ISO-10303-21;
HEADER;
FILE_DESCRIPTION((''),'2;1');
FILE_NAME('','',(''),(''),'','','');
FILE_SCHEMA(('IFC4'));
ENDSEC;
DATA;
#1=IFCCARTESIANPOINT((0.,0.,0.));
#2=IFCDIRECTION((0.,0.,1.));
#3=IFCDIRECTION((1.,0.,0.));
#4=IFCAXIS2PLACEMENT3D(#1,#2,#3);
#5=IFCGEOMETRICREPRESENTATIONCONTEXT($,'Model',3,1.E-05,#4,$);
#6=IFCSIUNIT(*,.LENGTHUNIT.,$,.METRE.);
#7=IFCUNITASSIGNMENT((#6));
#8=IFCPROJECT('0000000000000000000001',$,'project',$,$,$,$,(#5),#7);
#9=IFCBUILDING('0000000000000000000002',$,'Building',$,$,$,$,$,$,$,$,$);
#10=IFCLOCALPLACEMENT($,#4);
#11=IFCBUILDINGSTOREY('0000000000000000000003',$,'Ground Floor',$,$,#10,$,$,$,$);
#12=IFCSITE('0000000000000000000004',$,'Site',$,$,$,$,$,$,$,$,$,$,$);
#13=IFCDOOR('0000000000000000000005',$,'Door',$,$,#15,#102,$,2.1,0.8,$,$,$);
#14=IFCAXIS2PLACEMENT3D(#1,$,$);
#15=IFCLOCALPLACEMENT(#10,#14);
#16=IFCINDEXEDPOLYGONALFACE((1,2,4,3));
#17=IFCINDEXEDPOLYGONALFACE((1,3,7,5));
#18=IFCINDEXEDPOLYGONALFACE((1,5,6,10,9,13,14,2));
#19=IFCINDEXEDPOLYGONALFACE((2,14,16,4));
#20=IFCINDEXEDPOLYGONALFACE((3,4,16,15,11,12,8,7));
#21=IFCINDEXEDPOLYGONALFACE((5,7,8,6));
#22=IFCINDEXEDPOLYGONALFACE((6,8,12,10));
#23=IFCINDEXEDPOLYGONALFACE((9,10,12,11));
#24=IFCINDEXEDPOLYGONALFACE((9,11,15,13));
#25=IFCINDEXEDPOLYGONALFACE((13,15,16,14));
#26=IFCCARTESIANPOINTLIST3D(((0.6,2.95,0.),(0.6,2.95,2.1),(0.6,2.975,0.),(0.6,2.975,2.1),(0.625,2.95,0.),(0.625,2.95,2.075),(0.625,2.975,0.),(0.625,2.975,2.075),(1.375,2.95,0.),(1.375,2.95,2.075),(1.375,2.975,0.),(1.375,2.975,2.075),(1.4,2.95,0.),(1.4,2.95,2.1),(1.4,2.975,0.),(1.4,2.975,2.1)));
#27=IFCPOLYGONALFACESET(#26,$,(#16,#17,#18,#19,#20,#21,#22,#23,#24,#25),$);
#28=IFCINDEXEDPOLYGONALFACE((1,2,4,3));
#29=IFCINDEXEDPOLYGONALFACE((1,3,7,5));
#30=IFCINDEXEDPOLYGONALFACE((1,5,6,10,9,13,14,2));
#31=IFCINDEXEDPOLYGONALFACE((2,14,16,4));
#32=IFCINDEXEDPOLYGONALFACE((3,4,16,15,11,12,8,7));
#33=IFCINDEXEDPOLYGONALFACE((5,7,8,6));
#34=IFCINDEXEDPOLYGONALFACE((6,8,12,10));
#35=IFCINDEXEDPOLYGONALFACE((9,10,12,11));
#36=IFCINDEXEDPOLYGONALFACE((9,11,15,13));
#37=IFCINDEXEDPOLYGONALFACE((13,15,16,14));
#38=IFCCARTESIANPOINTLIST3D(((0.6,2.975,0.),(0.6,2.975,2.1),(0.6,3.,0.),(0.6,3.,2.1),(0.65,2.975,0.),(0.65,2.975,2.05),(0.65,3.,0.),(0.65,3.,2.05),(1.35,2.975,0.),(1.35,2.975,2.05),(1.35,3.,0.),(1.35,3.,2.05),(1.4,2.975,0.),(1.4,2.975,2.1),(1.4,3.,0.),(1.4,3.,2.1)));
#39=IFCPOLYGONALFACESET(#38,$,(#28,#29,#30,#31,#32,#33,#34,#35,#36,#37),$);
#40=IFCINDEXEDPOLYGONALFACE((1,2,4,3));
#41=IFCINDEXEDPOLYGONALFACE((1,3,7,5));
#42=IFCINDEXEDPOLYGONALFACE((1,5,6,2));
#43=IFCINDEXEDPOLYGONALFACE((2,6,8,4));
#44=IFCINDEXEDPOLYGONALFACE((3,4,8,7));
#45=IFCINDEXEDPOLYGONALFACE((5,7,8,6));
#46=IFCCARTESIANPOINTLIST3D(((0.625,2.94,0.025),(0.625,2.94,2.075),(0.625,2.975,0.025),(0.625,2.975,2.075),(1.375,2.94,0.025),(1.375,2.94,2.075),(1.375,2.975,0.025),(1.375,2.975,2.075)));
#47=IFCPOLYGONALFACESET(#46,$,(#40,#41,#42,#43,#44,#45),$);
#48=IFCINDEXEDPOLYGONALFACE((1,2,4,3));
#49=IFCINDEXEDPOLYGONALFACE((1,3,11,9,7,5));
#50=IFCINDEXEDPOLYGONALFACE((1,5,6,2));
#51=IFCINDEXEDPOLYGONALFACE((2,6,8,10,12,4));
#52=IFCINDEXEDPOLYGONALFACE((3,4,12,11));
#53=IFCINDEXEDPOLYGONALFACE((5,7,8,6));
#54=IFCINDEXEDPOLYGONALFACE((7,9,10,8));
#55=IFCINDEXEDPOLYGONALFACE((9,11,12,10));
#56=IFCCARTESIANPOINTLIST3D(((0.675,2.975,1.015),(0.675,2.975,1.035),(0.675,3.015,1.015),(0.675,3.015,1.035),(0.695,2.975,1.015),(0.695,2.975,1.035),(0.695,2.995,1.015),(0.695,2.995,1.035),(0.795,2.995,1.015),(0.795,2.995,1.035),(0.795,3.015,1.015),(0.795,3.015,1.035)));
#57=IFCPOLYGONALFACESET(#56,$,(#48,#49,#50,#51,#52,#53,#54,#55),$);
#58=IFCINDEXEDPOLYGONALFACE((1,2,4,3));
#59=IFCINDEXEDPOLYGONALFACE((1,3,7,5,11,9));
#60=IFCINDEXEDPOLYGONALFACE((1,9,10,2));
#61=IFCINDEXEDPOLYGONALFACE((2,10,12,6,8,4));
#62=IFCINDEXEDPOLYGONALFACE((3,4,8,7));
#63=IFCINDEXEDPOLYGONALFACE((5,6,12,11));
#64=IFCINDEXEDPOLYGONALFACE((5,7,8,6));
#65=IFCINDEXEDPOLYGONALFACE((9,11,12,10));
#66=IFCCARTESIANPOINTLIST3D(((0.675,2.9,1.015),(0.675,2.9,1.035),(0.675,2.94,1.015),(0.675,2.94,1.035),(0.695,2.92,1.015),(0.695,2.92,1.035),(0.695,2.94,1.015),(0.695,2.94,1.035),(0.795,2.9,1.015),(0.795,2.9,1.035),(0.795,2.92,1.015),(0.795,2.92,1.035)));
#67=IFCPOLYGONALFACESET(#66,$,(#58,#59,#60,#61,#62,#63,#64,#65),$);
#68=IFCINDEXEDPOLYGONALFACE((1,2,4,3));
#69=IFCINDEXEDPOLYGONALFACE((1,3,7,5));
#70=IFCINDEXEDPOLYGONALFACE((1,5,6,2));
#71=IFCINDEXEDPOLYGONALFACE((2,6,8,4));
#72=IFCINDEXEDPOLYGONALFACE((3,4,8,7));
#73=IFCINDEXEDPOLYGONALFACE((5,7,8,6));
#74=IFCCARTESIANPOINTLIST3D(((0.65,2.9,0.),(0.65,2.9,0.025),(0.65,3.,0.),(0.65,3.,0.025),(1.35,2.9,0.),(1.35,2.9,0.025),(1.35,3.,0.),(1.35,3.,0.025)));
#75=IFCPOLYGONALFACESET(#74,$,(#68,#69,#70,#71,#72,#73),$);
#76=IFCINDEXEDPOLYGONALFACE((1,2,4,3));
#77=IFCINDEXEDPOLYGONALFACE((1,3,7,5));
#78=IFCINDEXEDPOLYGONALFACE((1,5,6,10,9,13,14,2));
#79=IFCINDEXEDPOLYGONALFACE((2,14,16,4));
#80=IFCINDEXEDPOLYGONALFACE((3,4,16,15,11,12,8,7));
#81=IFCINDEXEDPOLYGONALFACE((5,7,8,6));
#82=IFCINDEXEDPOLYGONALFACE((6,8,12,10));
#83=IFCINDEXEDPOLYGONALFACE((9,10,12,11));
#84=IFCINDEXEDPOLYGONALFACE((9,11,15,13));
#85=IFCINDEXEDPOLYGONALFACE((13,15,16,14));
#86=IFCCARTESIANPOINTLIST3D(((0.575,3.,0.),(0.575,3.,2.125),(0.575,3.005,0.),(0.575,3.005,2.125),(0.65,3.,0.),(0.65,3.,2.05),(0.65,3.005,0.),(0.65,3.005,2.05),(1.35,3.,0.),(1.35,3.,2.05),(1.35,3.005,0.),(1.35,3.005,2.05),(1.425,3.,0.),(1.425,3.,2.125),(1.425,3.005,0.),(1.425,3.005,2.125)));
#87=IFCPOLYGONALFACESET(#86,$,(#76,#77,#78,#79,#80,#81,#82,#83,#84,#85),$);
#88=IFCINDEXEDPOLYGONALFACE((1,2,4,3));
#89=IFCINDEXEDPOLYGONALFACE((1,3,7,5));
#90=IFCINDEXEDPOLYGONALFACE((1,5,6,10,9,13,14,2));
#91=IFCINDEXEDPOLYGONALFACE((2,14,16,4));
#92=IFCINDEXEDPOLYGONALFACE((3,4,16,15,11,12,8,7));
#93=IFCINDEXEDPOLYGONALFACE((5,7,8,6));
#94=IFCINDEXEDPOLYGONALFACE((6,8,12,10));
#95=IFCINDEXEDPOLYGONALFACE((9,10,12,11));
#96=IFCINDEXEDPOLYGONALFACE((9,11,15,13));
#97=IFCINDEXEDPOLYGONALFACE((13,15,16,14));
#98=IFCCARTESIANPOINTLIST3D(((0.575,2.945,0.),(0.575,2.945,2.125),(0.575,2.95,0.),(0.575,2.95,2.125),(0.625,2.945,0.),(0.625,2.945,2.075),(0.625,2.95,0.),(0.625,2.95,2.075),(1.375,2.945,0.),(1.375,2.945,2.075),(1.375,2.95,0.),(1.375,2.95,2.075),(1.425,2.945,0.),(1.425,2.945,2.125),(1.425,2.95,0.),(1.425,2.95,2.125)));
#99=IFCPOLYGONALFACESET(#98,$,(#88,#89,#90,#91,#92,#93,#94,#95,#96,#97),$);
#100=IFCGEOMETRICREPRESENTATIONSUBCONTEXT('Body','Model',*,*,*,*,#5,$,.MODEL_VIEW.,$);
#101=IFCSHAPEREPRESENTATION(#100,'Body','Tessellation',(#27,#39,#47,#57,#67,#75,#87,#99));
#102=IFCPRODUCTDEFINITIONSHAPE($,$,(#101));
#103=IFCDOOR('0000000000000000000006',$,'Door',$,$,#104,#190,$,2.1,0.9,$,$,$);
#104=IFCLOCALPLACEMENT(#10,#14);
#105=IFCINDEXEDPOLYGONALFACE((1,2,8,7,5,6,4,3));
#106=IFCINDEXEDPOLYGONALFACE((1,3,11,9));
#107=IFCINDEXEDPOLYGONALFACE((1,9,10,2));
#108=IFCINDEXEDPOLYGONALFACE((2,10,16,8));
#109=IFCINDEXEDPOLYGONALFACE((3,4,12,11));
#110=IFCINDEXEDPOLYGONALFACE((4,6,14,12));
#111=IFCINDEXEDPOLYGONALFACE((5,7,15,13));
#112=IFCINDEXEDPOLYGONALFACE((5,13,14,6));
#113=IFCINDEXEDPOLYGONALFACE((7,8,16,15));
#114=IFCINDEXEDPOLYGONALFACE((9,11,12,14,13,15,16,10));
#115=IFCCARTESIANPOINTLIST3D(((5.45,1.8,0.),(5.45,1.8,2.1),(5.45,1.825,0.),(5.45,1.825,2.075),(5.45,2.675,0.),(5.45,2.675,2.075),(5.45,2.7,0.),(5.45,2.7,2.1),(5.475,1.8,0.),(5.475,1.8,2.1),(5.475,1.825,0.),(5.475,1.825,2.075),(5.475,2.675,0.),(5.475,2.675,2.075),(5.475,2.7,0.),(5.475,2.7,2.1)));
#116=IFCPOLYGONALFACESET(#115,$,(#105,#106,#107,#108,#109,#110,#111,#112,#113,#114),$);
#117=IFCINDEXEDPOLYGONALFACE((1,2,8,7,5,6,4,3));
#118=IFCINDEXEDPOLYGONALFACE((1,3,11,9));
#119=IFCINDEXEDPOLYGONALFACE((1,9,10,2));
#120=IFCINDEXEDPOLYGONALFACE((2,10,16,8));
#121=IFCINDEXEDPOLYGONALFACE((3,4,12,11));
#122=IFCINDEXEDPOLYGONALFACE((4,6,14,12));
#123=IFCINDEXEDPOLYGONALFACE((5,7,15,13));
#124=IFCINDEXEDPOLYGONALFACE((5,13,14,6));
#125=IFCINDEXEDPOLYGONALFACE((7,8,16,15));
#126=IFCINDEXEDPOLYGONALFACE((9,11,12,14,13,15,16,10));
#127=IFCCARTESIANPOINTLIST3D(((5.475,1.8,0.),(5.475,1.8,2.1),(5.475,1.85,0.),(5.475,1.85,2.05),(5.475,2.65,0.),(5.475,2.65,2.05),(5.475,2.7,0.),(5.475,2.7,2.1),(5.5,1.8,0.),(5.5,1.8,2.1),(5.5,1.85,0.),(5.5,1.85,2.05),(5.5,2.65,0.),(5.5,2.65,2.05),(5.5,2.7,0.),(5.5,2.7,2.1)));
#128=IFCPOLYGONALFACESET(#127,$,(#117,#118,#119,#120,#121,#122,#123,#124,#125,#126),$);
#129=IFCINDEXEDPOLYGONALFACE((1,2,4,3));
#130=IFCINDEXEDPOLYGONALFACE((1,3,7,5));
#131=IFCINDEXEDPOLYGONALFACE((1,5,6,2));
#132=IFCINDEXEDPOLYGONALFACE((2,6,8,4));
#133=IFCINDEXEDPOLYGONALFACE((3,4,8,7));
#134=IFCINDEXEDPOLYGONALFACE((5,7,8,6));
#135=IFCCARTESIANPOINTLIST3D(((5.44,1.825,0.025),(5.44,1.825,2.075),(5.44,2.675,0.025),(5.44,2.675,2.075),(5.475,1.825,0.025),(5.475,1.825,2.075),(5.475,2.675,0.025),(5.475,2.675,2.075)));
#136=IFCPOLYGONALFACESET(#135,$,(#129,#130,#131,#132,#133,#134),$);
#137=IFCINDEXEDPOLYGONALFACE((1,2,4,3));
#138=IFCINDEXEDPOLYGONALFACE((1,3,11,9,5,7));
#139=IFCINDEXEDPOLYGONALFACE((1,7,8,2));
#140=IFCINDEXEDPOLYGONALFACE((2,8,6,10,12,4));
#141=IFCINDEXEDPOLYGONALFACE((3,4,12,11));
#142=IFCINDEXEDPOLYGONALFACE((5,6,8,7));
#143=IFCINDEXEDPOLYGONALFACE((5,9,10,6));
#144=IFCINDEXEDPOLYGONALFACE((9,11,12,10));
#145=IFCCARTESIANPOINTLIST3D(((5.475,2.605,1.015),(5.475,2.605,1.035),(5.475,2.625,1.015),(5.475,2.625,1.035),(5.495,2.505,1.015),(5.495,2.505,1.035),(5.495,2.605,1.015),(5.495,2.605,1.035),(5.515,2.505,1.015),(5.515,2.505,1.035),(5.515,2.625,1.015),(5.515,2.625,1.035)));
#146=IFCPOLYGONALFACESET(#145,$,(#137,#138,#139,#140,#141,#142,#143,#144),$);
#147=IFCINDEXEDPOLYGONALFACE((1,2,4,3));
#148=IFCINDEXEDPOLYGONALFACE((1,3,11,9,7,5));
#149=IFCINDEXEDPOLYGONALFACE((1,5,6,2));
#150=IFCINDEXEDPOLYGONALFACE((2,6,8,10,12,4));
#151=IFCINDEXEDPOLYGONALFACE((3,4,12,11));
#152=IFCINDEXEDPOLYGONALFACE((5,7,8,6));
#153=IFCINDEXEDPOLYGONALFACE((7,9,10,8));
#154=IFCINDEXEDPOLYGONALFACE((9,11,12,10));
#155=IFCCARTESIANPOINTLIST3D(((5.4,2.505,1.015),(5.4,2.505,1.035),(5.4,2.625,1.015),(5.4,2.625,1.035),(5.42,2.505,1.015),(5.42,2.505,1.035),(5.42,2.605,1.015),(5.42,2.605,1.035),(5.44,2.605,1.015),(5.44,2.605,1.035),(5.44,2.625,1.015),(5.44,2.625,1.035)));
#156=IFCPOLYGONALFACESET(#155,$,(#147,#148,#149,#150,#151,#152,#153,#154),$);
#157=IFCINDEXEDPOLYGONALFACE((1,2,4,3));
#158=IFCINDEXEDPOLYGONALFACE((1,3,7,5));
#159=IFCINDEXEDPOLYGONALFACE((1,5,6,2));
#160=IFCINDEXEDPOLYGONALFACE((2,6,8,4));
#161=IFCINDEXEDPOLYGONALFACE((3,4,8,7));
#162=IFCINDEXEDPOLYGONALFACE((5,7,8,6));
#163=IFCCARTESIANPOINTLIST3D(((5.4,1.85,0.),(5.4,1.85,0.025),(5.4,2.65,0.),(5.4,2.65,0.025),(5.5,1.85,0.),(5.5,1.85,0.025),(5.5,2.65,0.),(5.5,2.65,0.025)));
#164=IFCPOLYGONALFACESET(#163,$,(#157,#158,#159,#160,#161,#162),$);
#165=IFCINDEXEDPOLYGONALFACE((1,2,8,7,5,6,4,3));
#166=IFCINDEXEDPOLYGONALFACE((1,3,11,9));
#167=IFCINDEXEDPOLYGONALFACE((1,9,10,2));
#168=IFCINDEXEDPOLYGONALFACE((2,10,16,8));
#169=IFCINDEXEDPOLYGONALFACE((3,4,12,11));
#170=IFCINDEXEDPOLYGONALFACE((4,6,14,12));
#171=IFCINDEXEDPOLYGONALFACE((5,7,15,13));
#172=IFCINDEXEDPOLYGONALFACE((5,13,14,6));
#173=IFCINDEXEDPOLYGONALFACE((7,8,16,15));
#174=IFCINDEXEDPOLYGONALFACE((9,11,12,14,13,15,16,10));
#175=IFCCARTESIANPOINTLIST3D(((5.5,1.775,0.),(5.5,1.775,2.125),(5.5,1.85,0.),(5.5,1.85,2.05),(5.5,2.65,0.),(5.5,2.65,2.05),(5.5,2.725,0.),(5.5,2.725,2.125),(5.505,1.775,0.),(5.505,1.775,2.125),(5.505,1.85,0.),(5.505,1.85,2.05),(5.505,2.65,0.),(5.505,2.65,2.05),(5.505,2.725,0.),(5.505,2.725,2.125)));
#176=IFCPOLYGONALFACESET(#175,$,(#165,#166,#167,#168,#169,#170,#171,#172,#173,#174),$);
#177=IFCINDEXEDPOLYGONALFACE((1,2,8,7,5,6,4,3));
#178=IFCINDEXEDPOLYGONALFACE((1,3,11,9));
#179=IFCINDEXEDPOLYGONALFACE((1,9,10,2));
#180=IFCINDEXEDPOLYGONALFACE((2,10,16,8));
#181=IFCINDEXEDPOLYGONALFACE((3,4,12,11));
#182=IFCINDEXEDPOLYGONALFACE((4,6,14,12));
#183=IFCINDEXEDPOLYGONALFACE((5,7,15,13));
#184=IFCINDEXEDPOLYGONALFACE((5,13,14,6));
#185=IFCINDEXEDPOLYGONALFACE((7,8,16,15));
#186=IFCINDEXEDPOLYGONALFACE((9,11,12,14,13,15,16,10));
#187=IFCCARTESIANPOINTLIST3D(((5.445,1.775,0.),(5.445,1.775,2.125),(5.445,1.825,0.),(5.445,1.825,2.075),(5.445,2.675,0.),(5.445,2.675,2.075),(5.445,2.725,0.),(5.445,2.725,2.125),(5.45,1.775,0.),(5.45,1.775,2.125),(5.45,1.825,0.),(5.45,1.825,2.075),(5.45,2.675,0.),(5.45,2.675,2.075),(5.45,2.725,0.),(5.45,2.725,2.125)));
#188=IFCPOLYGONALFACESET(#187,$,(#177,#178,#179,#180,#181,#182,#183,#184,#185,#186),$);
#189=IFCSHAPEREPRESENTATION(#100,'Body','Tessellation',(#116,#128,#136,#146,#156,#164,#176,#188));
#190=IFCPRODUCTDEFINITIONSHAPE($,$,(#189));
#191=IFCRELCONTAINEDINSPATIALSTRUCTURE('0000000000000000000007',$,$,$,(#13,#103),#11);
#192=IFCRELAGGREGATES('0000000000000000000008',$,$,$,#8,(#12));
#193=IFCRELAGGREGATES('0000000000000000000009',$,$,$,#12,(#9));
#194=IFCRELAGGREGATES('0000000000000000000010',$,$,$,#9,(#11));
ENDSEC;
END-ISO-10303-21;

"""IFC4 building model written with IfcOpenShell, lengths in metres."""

from ifc_helpers import new_model, si_unit, frame, origin_with_axes, place, context, subcontext, project, spatial, line, indexed_curve, outline, extrude, element, save


model = new_model("IFC4")

# Units and contexts
model_context = context("Model", 3, precision=1e-05, world=origin_with_axes())
body_context = subcontext(model_context, "Body", "Model", "MODEL_VIEW")
ifc_project = project(units=[si_unit("LENGTHUNIT", "METRE")], contexts=[model_context])

# Site, building, storey
site = spatial("IfcSite", under=ifc_project, Name="Site")
building = spatial("IfcBuilding", under=site, Name="Building")
storey_placement = place(None, origin_with_axes())
storey = spatial("IfcBuildingStorey", under=building, at=storey_placement, Name="Ground Floor")

# Doors
door_1_placement = place(storey_placement, frame((1.4, 3.0, 0.0), z_axis=(0.0, 0.0, 1.0), x_axis=(-1.0, 0.0, 0.0)))
element("IfcDoor", 1, at=door_1_placement, inside=storey, Name="Door", OverallHeight=2.1, OverallWidth=0.8, context=body_context, shape_type="SweptSolid", body=[
    extrude(outline(indexed_curve([(0.0, 0.0), (0.0, 2.1), (0.8, 2.1), (0.8, 0.0), (0.775, 0.0), (0.775, 2.075), (0.025, 2.075), (0.025, 0.0)], segments=[line(1, 2, 3, 4, 5, 6, 7, 8, 1)])), frame((0.0, 0.025, 0.0), z_axis=(0.0, -1.0, 0.0), x_axis=(1.0, 0.0, 0.0)), (0.0, 0.0, -1.0), 0.025),
    extrude(outline(indexed_curve([(0.0, 0.0), (0.0, 2.1), (0.8, 2.1), (0.8, 0.0), (0.75, 0.0), (0.75, 2.05), (0.05, 2.05), (0.05, 0.0)], segments=[line(1, 2, 3, 4, 5, 6, 7, 8, 1)])), frame((0.0, 0.0, 0.0), z_axis=(0.0, -1.0, 0.0), x_axis=(1.0, 0.0, 0.0)), (0.0, 0.0, -1.0), 0.025),
    extrude(outline(indexed_curve([(0.0, 0.0), (0.75, 0.0), (0.75, 0.035), (0.0, 0.035)], segments=[line(1, 2, 3, 4, 1)])), frame((0.025, 0.025, 0.025), z_axis=(0.0, 0.0, 1.0), x_axis=(1.0, 0.0, 0.0)), (0.0, 0.0, 1.0), 2.05),
    extrude(outline(indexed_curve([(0.0, 0.0), (0.0, -0.04), (-0.12, -0.04), (-0.12, -0.02), (-0.02, -0.02), (-0.02, 0.0)], segments=[line(1, 2, 3, 4, 5, 6, 1)])), frame((0.725, 0.025, 1.015), z_axis=(0.0, 0.0, 1.0), x_axis=(1.0, 0.0, 0.0)), (0.0, 0.0, 1.0), 0.02),
    extrude(outline(indexed_curve([(0.0, 0.0), (0.0, 0.04), (-0.12, 0.04), (-0.12, 0.02), (-0.02, 0.02), (-0.02, 0.0)], segments=[line(1, 2, 3, 4, 5, 6, 1)])), frame((0.725, 0.06, 1.015), z_axis=(0.0, 0.0, 1.0), x_axis=(1.0, 0.0, 0.0)), (0.0, 0.0, 1.0), 0.02),
    extrude(outline(indexed_curve([(0.0, 0.0), (0.7, 0.0), (0.7, 0.1), (0.0, 0.1)], segments=[line(1, 2, 3, 4, 1)])), frame((0.05, 0.0, 0.0), z_axis=(0.0, 0.0, 1.0), x_axis=(1.0, 0.0, 0.0)), (0.0, 0.0, 1.0), 0.025),
    extrude(outline(indexed_curve([(0.0, 0.0), (0.0, 2.125), (0.85, 2.125), (0.85, 0.0), (0.775, 0.0), (0.775, 2.05), (0.075, 2.05), (0.075, 0.0)], segments=[line(1, 2, 3, 4, 5, 6, 7, 8, 1)])), frame((-0.025, -0.005, 0.0), z_axis=(0.0, -1.0, 0.0), x_axis=(1.0, 0.0, 0.0)), (0.0, 0.0, -1.0), 0.005),
    extrude(outline(indexed_curve([(0.0, 0.0), (0.0, 2.125), (0.85, 2.125), (0.85, 0.0), (0.8, 0.0), (0.8, 2.075), (0.05, 2.075), (0.05, 0.0)], segments=[line(1, 2, 3, 4, 5, 6, 7, 8, 1)])), frame((-0.025, 0.05, 0.0), z_axis=(0.0, -1.0, 0.0), x_axis=(1.0, 0.0, 0.0)), (0.0, 0.0, -1.0), 0.005),
])
door_2_placement = place(storey_placement, frame((5.5, 1.8, 0.0), z_axis=(0.0, 0.0, 1.0), x_axis=(0.0, 1.0, 0.0)))
element("IfcDoor", 2, at=door_2_placement, inside=storey, Name="Door", OverallHeight=2.1, OverallWidth=0.9, context=body_context, shape_type="SweptSolid", body=[
    extrude(outline(indexed_curve([(0.0, 0.0), (0.0, 2.1), (0.9, 2.1), (0.9, 0.0), (0.875, 0.0), (0.875, 2.075), (0.025, 2.075), (0.025, 0.0)], segments=[line(1, 2, 3, 4, 5, 6, 7, 8, 1)])), frame((0.0, 0.025, 0.0), z_axis=(0.0, -1.0, 0.0), x_axis=(1.0, 0.0, 0.0)), (0.0, 0.0, -1.0), 0.025),
    extrude(outline(indexed_curve([(0.0, 0.0), (0.0, 2.1), (0.9, 2.1), (0.9, 0.0), (0.85, 0.0), (0.85, 2.05), (0.05, 2.05), (0.05, 0.0)], segments=[line(1, 2, 3, 4, 5, 6, 7, 8, 1)])), frame((0.0, 0.0, 0.0), z_axis=(0.0, -1.0, 0.0), x_axis=(1.0, 0.0, 0.0)), (0.0, 0.0, -1.0), 0.025),
    extrude(outline(indexed_curve([(0.0, 0.0), (0.85, 0.0), (0.85, 0.035), (0.0, 0.035)], segments=[line(1, 2, 3, 4, 1)])), frame((0.025, 0.025, 0.025), z_axis=(0.0, 0.0, 1.0), x_axis=(1.0, 0.0, 0.0)), (0.0, 0.0, 1.0), 2.05),
    extrude(outline(indexed_curve([(0.0, 0.0), (0.0, -0.04), (-0.12, -0.04), (-0.12, -0.02), (-0.02, -0.02), (-0.02, 0.0)], segments=[line(1, 2, 3, 4, 5, 6, 1)])), frame((0.825, 0.025, 1.015), z_axis=(0.0, 0.0, 1.0), x_axis=(1.0, 0.0, 0.0)), (0.0, 0.0, 1.0), 0.02),
    extrude(outline(indexed_curve([(0.0, 0.0), (0.0, 0.04), (-0.12, 0.04), (-0.12, 0.02), (-0.02, 0.02), (-0.02, 0.0)], segments=[line(1, 2, 3, 4, 5, 6, 1)])), frame((0.825, 0.06, 1.015), z_axis=(0.0, 0.0, 1.0), x_axis=(1.0, 0.0, 0.0)), (0.0, 0.0, 1.0), 0.02),
    extrude(outline(indexed_curve([(0.0, 0.0), (0.8, 0.0), (0.8, 0.1), (0.0, 0.1)], segments=[line(1, 2, 3, 4, 1)])), frame((0.05, 0.0, 0.0), z_axis=(0.0, 0.0, 1.0), x_axis=(1.0, 0.0, 0.0)), (0.0, 0.0, 1.0), 0.025),
    extrude(outline(indexed_curve([(0.0, 0.0), (0.0, 2.125), (0.95, 2.125), (0.95, 0.0), (0.875, 0.0), (0.875, 2.05), (0.075, 2.05), (0.075, 0.0)], segments=[line(1, 2, 3, 4, 5, 6, 7, 8, 1)])), frame((-0.025, -0.005, 0.0), z_axis=(0.0, -1.0, 0.0), x_axis=(1.0, 0.0, 0.0)), (0.0, 0.0, -1.0), 0.005),
    extrude(outline(indexed_curve([(0.0, 0.0), (0.0, 2.125), (0.95, 2.125), (0.95, 0.0), (0.9, 0.0), (0.9, 2.075), (0.05, 2.075), (0.05, 0.0)], segments=[line(1, 2, 3, 4, 5, 6, 7, 8, 1)])), frame((-0.025, 0.05, 0.0), z_axis=(0.0, -1.0, 0.0), x_axis=(1.0, 0.0, 0.0)), (0.0, 0.0, -1.0), 0.005),
])

save(model, "model.ifc")
